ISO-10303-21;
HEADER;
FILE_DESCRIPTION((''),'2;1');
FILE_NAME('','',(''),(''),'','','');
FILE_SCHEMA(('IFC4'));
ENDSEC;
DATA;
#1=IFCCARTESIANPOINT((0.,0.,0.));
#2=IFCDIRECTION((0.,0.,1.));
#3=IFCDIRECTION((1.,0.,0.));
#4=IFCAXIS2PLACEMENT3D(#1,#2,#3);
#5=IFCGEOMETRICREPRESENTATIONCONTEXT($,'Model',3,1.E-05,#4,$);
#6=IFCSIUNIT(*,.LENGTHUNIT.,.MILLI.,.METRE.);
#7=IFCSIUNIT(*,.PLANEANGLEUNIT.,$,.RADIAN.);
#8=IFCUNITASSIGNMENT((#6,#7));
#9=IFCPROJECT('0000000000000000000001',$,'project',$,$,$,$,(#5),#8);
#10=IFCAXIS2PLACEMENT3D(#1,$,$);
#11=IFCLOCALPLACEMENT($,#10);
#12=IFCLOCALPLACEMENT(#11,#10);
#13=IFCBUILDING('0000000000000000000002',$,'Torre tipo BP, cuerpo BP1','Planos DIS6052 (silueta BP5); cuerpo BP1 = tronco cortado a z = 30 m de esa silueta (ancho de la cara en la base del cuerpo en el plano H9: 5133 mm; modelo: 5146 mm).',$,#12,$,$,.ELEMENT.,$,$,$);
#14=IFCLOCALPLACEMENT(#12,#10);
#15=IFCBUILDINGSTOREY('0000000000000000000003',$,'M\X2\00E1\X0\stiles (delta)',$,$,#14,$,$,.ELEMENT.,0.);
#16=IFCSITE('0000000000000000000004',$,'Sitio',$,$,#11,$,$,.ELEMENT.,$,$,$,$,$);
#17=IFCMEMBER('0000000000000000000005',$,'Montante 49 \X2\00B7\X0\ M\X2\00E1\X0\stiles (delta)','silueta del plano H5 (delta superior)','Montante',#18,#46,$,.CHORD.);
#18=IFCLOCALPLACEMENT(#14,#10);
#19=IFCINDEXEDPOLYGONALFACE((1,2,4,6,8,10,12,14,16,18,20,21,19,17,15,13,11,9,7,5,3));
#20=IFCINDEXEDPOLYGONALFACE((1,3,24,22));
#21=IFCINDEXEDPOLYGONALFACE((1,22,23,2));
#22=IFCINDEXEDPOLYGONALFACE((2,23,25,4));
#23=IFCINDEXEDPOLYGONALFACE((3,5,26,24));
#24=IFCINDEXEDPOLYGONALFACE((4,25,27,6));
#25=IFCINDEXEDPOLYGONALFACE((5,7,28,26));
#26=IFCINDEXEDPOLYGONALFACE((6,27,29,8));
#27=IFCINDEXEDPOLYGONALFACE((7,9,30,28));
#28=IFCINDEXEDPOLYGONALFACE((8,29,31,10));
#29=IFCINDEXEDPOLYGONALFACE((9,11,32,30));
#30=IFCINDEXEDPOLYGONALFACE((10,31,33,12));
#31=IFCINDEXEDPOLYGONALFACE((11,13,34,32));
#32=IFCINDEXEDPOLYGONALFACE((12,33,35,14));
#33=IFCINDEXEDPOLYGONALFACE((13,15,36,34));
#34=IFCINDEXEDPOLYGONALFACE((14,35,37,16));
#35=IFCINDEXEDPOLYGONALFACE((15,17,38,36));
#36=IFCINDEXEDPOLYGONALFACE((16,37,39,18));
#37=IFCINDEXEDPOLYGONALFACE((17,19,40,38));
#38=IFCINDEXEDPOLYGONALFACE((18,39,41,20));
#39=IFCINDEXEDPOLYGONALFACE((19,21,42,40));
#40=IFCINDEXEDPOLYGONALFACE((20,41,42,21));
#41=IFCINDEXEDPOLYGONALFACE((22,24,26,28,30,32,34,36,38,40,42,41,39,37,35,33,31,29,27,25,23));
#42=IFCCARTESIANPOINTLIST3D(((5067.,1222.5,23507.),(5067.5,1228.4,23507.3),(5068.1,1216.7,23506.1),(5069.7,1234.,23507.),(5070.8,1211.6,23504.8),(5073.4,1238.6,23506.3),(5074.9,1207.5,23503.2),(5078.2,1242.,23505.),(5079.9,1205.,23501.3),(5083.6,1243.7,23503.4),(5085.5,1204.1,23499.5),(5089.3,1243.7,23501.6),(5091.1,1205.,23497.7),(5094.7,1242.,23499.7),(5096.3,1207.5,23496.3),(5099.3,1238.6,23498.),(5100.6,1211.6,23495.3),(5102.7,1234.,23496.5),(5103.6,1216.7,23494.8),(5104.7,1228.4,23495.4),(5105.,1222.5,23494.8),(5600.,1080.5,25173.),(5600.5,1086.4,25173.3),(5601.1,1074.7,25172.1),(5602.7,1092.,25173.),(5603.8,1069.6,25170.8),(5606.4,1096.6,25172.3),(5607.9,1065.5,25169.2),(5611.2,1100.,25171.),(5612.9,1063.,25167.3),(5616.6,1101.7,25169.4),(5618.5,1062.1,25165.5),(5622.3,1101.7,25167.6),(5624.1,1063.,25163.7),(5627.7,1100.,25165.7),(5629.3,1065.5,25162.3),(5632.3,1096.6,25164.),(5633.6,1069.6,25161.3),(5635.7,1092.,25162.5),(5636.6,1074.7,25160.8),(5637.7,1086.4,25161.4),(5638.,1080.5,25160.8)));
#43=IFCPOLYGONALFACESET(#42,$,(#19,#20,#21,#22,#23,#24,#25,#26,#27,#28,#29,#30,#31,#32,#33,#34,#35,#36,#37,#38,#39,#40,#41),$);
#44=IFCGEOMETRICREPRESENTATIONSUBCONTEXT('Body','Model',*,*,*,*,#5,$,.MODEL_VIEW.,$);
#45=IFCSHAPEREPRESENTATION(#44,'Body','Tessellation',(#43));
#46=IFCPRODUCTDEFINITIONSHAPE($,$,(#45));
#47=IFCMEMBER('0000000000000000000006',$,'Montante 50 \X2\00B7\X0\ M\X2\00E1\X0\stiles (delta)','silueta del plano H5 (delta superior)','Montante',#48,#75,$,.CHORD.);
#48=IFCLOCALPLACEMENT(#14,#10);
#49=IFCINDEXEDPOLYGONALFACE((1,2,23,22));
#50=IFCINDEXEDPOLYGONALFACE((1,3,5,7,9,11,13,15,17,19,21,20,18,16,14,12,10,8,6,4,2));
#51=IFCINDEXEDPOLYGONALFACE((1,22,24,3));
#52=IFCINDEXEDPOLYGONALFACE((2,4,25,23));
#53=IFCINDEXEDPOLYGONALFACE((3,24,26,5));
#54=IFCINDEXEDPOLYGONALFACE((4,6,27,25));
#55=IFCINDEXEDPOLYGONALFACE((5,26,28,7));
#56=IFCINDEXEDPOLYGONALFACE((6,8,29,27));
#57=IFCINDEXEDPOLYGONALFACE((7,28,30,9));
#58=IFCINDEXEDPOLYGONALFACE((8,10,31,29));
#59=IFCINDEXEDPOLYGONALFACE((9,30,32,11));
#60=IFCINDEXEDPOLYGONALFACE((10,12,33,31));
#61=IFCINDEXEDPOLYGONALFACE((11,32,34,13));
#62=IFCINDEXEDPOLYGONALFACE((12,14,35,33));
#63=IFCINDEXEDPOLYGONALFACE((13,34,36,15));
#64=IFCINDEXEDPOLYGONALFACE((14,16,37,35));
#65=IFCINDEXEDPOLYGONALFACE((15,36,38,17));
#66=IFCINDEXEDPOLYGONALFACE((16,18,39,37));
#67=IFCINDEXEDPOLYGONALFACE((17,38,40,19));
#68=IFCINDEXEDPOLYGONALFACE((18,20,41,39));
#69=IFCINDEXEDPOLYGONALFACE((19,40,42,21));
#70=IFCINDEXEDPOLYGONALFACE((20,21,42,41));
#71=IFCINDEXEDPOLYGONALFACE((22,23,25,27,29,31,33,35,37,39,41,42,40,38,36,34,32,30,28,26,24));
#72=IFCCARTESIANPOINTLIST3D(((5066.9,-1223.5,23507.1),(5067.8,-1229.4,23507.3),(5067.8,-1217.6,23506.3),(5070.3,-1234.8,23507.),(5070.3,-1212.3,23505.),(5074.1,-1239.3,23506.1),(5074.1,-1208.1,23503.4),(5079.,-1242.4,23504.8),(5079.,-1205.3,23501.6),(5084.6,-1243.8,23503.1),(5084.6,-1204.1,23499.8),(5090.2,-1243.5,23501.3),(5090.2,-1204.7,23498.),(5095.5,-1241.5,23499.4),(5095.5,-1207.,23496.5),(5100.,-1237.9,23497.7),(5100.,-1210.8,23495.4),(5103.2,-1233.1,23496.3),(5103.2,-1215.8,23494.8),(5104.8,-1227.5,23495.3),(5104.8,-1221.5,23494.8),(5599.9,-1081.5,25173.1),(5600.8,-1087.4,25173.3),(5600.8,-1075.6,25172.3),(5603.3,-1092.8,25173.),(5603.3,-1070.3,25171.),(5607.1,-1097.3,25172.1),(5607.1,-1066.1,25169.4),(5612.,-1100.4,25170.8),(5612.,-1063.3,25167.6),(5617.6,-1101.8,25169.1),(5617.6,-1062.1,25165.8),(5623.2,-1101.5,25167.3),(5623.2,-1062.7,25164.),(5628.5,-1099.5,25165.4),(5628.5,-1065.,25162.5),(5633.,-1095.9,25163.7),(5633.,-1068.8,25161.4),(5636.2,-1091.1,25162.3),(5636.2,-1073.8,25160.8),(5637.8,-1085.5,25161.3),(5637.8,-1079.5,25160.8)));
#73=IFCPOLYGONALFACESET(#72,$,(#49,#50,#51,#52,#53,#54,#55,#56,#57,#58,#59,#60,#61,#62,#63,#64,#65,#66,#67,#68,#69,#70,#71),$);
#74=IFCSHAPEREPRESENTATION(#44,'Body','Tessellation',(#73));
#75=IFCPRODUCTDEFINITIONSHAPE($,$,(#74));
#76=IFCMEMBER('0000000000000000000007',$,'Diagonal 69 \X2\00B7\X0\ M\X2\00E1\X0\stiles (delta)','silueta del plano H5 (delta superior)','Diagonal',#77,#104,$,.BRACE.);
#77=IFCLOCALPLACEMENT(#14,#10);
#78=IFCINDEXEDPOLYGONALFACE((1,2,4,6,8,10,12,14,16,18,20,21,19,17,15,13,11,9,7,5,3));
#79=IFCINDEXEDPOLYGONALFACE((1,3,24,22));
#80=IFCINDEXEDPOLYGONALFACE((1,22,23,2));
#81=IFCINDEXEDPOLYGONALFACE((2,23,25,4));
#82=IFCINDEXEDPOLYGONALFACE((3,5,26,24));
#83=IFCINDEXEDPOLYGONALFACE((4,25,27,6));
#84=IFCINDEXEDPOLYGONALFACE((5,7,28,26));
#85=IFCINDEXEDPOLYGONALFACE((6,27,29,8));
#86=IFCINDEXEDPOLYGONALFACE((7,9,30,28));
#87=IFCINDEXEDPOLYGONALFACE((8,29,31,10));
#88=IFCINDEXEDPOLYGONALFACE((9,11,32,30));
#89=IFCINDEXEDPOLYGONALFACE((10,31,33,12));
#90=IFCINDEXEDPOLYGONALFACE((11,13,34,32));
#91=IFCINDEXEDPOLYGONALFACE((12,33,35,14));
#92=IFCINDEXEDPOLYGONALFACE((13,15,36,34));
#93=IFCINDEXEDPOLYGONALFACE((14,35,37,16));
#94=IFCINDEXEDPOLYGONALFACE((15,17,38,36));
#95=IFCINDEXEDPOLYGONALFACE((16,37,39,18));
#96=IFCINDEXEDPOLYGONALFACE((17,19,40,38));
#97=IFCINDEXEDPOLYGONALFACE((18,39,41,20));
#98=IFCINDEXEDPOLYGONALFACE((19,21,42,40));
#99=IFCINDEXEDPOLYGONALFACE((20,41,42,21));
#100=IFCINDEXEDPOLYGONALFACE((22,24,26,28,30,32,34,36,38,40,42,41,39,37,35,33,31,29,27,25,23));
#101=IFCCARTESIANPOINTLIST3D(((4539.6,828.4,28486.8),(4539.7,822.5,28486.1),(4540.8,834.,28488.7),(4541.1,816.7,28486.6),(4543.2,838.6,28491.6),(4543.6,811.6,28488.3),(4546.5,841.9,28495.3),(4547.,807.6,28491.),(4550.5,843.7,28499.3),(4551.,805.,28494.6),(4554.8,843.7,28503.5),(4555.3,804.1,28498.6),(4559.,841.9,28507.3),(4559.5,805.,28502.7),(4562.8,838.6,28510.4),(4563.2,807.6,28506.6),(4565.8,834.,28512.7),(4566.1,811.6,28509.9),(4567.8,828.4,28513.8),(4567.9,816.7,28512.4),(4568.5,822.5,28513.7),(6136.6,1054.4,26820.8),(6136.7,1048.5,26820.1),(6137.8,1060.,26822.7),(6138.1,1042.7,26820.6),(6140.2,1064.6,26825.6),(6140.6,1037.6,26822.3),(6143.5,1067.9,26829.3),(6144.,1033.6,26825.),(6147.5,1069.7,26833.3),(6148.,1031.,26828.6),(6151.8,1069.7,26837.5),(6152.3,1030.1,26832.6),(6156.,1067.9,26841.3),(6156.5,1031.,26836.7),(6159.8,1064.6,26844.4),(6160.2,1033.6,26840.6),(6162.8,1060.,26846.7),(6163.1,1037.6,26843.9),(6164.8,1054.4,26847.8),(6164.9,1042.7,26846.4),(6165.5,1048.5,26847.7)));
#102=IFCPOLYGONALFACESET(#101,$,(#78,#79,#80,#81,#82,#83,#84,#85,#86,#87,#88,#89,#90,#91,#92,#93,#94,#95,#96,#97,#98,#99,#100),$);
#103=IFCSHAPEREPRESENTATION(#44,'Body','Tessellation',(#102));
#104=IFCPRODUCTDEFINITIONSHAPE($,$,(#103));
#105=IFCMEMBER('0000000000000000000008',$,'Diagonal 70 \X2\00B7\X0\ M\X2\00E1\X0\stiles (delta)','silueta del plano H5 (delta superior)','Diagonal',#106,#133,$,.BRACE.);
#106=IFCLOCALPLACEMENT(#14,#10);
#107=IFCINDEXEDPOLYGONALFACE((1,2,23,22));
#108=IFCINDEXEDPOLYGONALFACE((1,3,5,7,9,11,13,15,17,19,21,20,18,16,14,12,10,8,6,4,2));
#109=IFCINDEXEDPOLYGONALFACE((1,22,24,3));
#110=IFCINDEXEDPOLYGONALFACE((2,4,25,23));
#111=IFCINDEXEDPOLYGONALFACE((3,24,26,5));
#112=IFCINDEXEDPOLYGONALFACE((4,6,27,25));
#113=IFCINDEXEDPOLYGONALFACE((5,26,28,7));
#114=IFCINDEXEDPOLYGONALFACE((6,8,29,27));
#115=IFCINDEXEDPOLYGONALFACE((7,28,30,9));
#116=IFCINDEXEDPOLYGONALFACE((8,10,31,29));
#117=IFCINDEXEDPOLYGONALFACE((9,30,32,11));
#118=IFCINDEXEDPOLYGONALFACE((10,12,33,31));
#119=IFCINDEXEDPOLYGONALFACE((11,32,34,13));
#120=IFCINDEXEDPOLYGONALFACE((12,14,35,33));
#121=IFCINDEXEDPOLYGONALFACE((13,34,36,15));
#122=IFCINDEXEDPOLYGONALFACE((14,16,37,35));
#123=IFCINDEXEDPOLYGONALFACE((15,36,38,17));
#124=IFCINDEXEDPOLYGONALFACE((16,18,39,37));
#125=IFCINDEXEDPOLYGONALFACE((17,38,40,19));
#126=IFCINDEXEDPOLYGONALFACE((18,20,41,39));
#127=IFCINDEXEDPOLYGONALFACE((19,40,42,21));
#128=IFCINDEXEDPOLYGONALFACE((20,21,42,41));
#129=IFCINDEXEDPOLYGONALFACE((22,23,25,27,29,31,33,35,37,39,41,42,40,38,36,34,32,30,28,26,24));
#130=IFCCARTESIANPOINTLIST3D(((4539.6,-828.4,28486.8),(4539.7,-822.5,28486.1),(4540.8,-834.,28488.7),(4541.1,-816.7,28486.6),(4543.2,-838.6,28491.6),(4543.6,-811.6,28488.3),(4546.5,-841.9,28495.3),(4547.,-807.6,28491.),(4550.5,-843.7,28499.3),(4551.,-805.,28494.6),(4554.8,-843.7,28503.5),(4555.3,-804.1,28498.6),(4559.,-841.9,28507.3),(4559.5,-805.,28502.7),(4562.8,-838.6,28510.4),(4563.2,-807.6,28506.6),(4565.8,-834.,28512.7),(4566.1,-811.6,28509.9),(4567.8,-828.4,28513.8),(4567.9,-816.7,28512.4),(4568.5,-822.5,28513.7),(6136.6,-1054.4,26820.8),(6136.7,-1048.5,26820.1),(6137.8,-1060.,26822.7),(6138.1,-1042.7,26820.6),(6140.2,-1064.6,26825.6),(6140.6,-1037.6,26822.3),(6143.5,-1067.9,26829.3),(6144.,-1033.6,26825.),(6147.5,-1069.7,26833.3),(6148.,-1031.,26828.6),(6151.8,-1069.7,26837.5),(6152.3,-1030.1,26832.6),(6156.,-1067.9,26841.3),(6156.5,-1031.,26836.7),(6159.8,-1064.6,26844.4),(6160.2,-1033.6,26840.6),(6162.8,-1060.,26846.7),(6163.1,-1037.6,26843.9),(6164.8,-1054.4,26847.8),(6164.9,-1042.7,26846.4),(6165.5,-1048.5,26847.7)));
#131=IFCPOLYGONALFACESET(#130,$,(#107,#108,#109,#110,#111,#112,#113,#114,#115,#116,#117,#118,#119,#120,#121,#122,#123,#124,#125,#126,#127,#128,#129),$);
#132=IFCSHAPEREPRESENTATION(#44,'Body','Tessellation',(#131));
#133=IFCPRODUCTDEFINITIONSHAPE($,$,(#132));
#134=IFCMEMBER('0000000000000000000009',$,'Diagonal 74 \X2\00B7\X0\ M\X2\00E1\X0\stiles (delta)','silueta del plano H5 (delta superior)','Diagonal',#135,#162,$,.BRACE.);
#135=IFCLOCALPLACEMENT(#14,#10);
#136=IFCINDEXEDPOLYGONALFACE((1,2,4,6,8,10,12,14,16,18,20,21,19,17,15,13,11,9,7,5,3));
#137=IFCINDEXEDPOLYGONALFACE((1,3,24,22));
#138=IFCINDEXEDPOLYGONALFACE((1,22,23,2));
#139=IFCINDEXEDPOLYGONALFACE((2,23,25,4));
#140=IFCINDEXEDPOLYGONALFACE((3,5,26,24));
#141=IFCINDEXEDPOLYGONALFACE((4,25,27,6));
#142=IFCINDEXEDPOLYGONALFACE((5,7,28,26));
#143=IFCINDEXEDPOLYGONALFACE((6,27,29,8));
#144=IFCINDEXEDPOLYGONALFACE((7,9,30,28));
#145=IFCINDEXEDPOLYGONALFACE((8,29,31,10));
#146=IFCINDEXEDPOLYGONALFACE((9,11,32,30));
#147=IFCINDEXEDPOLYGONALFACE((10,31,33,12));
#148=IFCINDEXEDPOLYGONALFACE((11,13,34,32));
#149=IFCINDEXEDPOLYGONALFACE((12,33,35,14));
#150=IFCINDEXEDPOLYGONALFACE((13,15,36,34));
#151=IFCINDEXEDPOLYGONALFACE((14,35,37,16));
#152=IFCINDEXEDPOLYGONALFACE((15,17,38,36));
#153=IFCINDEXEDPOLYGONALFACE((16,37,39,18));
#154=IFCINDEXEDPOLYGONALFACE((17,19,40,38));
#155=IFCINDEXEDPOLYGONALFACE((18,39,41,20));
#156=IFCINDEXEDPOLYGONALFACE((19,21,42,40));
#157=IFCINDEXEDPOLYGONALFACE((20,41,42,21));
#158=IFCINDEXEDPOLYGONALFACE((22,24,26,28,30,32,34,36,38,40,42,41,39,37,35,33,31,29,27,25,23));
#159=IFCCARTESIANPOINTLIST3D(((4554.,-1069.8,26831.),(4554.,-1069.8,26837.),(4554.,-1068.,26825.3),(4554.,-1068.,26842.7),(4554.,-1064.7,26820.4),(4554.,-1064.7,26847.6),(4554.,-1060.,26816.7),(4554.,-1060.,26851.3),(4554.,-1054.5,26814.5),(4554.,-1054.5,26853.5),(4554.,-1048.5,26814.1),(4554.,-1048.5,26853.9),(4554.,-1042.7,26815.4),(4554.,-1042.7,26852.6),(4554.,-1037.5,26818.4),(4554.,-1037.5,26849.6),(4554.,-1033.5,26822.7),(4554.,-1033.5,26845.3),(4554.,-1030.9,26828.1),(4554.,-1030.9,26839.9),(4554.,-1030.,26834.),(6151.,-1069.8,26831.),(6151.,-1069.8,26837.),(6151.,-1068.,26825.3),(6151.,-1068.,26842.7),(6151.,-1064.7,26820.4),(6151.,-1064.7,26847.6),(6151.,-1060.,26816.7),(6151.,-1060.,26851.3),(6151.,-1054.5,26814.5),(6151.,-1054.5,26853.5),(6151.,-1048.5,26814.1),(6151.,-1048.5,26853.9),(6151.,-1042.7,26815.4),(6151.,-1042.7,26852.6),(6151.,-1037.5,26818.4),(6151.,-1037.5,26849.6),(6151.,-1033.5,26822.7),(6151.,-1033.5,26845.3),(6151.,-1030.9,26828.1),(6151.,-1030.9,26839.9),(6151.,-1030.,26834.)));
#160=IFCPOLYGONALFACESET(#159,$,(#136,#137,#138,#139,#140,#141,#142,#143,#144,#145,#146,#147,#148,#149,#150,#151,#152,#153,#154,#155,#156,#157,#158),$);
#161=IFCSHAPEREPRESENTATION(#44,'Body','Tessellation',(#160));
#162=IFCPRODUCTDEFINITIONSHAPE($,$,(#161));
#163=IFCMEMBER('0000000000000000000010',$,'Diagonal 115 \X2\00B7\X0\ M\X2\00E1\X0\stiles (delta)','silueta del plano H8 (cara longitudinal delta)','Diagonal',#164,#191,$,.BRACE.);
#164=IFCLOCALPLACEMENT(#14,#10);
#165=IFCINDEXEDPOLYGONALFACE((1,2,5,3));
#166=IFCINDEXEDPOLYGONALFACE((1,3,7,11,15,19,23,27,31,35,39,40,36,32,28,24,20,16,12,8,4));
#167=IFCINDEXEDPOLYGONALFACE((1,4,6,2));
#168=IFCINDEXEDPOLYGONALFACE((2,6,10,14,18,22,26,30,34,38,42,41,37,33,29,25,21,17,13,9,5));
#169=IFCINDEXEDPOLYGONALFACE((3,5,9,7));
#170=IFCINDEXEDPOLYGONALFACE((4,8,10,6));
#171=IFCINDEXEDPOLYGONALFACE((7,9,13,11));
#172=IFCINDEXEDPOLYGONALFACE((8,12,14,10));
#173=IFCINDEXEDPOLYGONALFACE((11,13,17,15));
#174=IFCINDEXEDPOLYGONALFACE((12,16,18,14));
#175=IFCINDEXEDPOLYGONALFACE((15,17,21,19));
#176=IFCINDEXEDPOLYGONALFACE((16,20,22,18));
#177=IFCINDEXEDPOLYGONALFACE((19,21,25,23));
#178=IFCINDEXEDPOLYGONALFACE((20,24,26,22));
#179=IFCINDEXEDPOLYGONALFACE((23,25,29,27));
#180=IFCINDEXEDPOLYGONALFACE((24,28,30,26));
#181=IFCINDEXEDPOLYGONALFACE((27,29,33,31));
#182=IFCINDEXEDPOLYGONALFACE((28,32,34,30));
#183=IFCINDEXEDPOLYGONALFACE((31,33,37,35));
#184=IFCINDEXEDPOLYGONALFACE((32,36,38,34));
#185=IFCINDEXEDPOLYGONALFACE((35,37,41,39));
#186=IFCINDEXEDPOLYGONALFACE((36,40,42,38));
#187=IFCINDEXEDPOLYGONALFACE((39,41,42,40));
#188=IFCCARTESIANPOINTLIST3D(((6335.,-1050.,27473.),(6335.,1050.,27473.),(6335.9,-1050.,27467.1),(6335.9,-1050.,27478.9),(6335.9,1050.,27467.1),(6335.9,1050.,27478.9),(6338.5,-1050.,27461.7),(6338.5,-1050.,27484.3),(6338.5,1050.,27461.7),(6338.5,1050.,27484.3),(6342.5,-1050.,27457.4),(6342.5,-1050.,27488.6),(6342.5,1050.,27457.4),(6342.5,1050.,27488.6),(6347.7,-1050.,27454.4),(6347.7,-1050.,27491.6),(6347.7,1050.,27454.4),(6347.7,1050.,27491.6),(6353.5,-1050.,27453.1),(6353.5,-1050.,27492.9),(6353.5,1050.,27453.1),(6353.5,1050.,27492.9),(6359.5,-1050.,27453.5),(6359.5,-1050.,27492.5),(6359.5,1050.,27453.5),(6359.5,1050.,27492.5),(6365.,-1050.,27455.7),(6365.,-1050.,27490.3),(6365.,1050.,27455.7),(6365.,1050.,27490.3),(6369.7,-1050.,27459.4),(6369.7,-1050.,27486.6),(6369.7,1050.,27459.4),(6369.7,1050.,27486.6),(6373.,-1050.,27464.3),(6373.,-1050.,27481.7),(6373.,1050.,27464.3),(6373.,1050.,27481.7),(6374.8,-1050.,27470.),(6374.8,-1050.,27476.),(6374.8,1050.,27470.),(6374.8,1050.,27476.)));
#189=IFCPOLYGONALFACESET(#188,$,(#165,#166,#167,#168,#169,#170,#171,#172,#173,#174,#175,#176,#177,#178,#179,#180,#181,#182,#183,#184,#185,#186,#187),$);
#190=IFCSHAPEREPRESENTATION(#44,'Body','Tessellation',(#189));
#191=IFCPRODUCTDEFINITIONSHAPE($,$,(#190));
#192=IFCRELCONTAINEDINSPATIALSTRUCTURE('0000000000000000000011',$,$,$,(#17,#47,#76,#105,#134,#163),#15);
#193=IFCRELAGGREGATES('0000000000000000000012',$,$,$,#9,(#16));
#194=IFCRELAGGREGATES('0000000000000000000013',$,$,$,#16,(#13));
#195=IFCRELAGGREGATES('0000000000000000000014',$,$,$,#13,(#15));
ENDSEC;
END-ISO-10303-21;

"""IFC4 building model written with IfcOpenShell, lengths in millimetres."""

from ifc_helpers import new_model, si_unit, frame, origin, origin_with_axes, place, context, subcontext, project, spatial, circle, extrude, element, save


model = new_model("IFC4")

# Units and contexts
model_context = context("Model", 3, precision=1e-05, world=origin_with_axes())
body_context = subcontext(model_context, "Body", "Model", "MODEL_VIEW")
ifc_project = project(units=[si_unit("LENGTHUNIT", "METRE", prefix="MILLI"), si_unit("PLANEANGLEUNIT", "RADIAN")], contexts=[model_context])

# Site, building, storey
site_placement = place(None, origin())
site = spatial("IfcSite", under=ifc_project, at=site_placement, Name="Sitio", CompositionType="ELEMENT")
building_placement = place(site_placement, origin())
building = spatial("IfcBuilding", under=site, at=building_placement, Name="Torre tipo BP, cuerpo BP1", Description="Planos DIS6052 (silueta BP5); cuerpo BP1 = tronco cortado a z = 30 m de esa silueta (ancho de la cara en la base del cuerpo en el plano H9: 5133 mm; modelo: 5146 mm).", CompositionType="ELEMENT")
storey_placement = place(building_placement, origin())
storey = spatial("IfcBuildingStorey", under=building, at=storey_placement, Name="Mástiles (delta)", CompositionType="ELEMENT", Elevation=0.0)

# Members
for number, where, z_axis, x_axis, name in (
    (1, (5619.0, 1082.0, 25167.0), (-0.303714, 0.080915, -0.949321), (-0.024656, -0.996721, -0.077067), "Montante 49 · Mástiles (delta)"),
    (2, (5619.0, -1082.0, 25167.0), (-0.303714, -0.080915, -0.949321), (-0.952763, 0.025793, 0.302617), "Montante 50 · Mástiles (delta)"),
):
    element("IfcMember", number, at=place(storey_placement, frame(where, z_axis=z_axis, x_axis=x_axis)), inside=storey, Name=name, Description="silueta del plano H5 (delta superior)", ObjectType="Montante", PredefinedType="CHORD", context=body_context, shape_type="SweptSolid", body=[
        extrude(circle(Radius=20.0), None, (0.0, 0.0, 1.0), 1754.9),
    ])
for number, where, z_axis, x_axis, name in (
    (3, (4554.0, 824.0, 28500.0), (0.688705, 0.097462, -0.718461), (0.067444, -0.995239, -0.070358), "Diagonal 69 · Mástiles (delta)"),
    (4, (4554.0, -824.0, 28500.0), (0.688705, -0.097462, -0.718461), (0.067444, 0.995239, -0.070358), "Diagonal 70 · Mástiles (delta)"),
):
    element("IfcMember", number, at=place(storey_placement, frame(where, z_axis=z_axis, x_axis=x_axis)), inside=storey, Name=name, Description="silueta del plano H5 (delta superior)", ObjectType="Diagonal", PredefinedType="BRACE", context=body_context, shape_type="SweptSolid", body=[
        extrude(circle(Radius=20.0), None, (0.0, 0.0, 1.0), 2318.8),
    ])
member_1_placement = place(storey_placement, frame((4554.0, -1050.0, 26834.0), z_axis=(1.0, 0.0, 0.0), x_axis=(0.0, 1.0, 0.0)))
element("IfcMember", 5, at=member_1_placement, inside=storey, Name="Diagonal 74 · Mástiles (delta)", Description="silueta del plano H5 (delta superior)", ObjectType="Diagonal", PredefinedType="BRACE", context=body_context, shape_type="SweptSolid", body=[
    extrude(circle(Radius=20.0), None, (0.0, 0.0, 1.0), 1597.0),
])
member_2_placement = place(storey_placement, frame((6355.0, -1050.0, 27473.0), z_axis=(0.0, 1.0, 0.0), x_axis=(-1.0, 0.0, 0.0)))
element("IfcMember", 6, at=member_2_placement, inside=storey, Name="Diagonal 115 · Mástiles (delta)", Description="silueta del plano H8 (cara longitudinal delta)", ObjectType="Diagonal", PredefinedType="BRACE", context=body_context, shape_type="SweptSolid", body=[
    extrude(circle(Radius=20.0), None, (0.0, 0.0, 1.0), 2100.0),
])

save(model, "model.ifc")
